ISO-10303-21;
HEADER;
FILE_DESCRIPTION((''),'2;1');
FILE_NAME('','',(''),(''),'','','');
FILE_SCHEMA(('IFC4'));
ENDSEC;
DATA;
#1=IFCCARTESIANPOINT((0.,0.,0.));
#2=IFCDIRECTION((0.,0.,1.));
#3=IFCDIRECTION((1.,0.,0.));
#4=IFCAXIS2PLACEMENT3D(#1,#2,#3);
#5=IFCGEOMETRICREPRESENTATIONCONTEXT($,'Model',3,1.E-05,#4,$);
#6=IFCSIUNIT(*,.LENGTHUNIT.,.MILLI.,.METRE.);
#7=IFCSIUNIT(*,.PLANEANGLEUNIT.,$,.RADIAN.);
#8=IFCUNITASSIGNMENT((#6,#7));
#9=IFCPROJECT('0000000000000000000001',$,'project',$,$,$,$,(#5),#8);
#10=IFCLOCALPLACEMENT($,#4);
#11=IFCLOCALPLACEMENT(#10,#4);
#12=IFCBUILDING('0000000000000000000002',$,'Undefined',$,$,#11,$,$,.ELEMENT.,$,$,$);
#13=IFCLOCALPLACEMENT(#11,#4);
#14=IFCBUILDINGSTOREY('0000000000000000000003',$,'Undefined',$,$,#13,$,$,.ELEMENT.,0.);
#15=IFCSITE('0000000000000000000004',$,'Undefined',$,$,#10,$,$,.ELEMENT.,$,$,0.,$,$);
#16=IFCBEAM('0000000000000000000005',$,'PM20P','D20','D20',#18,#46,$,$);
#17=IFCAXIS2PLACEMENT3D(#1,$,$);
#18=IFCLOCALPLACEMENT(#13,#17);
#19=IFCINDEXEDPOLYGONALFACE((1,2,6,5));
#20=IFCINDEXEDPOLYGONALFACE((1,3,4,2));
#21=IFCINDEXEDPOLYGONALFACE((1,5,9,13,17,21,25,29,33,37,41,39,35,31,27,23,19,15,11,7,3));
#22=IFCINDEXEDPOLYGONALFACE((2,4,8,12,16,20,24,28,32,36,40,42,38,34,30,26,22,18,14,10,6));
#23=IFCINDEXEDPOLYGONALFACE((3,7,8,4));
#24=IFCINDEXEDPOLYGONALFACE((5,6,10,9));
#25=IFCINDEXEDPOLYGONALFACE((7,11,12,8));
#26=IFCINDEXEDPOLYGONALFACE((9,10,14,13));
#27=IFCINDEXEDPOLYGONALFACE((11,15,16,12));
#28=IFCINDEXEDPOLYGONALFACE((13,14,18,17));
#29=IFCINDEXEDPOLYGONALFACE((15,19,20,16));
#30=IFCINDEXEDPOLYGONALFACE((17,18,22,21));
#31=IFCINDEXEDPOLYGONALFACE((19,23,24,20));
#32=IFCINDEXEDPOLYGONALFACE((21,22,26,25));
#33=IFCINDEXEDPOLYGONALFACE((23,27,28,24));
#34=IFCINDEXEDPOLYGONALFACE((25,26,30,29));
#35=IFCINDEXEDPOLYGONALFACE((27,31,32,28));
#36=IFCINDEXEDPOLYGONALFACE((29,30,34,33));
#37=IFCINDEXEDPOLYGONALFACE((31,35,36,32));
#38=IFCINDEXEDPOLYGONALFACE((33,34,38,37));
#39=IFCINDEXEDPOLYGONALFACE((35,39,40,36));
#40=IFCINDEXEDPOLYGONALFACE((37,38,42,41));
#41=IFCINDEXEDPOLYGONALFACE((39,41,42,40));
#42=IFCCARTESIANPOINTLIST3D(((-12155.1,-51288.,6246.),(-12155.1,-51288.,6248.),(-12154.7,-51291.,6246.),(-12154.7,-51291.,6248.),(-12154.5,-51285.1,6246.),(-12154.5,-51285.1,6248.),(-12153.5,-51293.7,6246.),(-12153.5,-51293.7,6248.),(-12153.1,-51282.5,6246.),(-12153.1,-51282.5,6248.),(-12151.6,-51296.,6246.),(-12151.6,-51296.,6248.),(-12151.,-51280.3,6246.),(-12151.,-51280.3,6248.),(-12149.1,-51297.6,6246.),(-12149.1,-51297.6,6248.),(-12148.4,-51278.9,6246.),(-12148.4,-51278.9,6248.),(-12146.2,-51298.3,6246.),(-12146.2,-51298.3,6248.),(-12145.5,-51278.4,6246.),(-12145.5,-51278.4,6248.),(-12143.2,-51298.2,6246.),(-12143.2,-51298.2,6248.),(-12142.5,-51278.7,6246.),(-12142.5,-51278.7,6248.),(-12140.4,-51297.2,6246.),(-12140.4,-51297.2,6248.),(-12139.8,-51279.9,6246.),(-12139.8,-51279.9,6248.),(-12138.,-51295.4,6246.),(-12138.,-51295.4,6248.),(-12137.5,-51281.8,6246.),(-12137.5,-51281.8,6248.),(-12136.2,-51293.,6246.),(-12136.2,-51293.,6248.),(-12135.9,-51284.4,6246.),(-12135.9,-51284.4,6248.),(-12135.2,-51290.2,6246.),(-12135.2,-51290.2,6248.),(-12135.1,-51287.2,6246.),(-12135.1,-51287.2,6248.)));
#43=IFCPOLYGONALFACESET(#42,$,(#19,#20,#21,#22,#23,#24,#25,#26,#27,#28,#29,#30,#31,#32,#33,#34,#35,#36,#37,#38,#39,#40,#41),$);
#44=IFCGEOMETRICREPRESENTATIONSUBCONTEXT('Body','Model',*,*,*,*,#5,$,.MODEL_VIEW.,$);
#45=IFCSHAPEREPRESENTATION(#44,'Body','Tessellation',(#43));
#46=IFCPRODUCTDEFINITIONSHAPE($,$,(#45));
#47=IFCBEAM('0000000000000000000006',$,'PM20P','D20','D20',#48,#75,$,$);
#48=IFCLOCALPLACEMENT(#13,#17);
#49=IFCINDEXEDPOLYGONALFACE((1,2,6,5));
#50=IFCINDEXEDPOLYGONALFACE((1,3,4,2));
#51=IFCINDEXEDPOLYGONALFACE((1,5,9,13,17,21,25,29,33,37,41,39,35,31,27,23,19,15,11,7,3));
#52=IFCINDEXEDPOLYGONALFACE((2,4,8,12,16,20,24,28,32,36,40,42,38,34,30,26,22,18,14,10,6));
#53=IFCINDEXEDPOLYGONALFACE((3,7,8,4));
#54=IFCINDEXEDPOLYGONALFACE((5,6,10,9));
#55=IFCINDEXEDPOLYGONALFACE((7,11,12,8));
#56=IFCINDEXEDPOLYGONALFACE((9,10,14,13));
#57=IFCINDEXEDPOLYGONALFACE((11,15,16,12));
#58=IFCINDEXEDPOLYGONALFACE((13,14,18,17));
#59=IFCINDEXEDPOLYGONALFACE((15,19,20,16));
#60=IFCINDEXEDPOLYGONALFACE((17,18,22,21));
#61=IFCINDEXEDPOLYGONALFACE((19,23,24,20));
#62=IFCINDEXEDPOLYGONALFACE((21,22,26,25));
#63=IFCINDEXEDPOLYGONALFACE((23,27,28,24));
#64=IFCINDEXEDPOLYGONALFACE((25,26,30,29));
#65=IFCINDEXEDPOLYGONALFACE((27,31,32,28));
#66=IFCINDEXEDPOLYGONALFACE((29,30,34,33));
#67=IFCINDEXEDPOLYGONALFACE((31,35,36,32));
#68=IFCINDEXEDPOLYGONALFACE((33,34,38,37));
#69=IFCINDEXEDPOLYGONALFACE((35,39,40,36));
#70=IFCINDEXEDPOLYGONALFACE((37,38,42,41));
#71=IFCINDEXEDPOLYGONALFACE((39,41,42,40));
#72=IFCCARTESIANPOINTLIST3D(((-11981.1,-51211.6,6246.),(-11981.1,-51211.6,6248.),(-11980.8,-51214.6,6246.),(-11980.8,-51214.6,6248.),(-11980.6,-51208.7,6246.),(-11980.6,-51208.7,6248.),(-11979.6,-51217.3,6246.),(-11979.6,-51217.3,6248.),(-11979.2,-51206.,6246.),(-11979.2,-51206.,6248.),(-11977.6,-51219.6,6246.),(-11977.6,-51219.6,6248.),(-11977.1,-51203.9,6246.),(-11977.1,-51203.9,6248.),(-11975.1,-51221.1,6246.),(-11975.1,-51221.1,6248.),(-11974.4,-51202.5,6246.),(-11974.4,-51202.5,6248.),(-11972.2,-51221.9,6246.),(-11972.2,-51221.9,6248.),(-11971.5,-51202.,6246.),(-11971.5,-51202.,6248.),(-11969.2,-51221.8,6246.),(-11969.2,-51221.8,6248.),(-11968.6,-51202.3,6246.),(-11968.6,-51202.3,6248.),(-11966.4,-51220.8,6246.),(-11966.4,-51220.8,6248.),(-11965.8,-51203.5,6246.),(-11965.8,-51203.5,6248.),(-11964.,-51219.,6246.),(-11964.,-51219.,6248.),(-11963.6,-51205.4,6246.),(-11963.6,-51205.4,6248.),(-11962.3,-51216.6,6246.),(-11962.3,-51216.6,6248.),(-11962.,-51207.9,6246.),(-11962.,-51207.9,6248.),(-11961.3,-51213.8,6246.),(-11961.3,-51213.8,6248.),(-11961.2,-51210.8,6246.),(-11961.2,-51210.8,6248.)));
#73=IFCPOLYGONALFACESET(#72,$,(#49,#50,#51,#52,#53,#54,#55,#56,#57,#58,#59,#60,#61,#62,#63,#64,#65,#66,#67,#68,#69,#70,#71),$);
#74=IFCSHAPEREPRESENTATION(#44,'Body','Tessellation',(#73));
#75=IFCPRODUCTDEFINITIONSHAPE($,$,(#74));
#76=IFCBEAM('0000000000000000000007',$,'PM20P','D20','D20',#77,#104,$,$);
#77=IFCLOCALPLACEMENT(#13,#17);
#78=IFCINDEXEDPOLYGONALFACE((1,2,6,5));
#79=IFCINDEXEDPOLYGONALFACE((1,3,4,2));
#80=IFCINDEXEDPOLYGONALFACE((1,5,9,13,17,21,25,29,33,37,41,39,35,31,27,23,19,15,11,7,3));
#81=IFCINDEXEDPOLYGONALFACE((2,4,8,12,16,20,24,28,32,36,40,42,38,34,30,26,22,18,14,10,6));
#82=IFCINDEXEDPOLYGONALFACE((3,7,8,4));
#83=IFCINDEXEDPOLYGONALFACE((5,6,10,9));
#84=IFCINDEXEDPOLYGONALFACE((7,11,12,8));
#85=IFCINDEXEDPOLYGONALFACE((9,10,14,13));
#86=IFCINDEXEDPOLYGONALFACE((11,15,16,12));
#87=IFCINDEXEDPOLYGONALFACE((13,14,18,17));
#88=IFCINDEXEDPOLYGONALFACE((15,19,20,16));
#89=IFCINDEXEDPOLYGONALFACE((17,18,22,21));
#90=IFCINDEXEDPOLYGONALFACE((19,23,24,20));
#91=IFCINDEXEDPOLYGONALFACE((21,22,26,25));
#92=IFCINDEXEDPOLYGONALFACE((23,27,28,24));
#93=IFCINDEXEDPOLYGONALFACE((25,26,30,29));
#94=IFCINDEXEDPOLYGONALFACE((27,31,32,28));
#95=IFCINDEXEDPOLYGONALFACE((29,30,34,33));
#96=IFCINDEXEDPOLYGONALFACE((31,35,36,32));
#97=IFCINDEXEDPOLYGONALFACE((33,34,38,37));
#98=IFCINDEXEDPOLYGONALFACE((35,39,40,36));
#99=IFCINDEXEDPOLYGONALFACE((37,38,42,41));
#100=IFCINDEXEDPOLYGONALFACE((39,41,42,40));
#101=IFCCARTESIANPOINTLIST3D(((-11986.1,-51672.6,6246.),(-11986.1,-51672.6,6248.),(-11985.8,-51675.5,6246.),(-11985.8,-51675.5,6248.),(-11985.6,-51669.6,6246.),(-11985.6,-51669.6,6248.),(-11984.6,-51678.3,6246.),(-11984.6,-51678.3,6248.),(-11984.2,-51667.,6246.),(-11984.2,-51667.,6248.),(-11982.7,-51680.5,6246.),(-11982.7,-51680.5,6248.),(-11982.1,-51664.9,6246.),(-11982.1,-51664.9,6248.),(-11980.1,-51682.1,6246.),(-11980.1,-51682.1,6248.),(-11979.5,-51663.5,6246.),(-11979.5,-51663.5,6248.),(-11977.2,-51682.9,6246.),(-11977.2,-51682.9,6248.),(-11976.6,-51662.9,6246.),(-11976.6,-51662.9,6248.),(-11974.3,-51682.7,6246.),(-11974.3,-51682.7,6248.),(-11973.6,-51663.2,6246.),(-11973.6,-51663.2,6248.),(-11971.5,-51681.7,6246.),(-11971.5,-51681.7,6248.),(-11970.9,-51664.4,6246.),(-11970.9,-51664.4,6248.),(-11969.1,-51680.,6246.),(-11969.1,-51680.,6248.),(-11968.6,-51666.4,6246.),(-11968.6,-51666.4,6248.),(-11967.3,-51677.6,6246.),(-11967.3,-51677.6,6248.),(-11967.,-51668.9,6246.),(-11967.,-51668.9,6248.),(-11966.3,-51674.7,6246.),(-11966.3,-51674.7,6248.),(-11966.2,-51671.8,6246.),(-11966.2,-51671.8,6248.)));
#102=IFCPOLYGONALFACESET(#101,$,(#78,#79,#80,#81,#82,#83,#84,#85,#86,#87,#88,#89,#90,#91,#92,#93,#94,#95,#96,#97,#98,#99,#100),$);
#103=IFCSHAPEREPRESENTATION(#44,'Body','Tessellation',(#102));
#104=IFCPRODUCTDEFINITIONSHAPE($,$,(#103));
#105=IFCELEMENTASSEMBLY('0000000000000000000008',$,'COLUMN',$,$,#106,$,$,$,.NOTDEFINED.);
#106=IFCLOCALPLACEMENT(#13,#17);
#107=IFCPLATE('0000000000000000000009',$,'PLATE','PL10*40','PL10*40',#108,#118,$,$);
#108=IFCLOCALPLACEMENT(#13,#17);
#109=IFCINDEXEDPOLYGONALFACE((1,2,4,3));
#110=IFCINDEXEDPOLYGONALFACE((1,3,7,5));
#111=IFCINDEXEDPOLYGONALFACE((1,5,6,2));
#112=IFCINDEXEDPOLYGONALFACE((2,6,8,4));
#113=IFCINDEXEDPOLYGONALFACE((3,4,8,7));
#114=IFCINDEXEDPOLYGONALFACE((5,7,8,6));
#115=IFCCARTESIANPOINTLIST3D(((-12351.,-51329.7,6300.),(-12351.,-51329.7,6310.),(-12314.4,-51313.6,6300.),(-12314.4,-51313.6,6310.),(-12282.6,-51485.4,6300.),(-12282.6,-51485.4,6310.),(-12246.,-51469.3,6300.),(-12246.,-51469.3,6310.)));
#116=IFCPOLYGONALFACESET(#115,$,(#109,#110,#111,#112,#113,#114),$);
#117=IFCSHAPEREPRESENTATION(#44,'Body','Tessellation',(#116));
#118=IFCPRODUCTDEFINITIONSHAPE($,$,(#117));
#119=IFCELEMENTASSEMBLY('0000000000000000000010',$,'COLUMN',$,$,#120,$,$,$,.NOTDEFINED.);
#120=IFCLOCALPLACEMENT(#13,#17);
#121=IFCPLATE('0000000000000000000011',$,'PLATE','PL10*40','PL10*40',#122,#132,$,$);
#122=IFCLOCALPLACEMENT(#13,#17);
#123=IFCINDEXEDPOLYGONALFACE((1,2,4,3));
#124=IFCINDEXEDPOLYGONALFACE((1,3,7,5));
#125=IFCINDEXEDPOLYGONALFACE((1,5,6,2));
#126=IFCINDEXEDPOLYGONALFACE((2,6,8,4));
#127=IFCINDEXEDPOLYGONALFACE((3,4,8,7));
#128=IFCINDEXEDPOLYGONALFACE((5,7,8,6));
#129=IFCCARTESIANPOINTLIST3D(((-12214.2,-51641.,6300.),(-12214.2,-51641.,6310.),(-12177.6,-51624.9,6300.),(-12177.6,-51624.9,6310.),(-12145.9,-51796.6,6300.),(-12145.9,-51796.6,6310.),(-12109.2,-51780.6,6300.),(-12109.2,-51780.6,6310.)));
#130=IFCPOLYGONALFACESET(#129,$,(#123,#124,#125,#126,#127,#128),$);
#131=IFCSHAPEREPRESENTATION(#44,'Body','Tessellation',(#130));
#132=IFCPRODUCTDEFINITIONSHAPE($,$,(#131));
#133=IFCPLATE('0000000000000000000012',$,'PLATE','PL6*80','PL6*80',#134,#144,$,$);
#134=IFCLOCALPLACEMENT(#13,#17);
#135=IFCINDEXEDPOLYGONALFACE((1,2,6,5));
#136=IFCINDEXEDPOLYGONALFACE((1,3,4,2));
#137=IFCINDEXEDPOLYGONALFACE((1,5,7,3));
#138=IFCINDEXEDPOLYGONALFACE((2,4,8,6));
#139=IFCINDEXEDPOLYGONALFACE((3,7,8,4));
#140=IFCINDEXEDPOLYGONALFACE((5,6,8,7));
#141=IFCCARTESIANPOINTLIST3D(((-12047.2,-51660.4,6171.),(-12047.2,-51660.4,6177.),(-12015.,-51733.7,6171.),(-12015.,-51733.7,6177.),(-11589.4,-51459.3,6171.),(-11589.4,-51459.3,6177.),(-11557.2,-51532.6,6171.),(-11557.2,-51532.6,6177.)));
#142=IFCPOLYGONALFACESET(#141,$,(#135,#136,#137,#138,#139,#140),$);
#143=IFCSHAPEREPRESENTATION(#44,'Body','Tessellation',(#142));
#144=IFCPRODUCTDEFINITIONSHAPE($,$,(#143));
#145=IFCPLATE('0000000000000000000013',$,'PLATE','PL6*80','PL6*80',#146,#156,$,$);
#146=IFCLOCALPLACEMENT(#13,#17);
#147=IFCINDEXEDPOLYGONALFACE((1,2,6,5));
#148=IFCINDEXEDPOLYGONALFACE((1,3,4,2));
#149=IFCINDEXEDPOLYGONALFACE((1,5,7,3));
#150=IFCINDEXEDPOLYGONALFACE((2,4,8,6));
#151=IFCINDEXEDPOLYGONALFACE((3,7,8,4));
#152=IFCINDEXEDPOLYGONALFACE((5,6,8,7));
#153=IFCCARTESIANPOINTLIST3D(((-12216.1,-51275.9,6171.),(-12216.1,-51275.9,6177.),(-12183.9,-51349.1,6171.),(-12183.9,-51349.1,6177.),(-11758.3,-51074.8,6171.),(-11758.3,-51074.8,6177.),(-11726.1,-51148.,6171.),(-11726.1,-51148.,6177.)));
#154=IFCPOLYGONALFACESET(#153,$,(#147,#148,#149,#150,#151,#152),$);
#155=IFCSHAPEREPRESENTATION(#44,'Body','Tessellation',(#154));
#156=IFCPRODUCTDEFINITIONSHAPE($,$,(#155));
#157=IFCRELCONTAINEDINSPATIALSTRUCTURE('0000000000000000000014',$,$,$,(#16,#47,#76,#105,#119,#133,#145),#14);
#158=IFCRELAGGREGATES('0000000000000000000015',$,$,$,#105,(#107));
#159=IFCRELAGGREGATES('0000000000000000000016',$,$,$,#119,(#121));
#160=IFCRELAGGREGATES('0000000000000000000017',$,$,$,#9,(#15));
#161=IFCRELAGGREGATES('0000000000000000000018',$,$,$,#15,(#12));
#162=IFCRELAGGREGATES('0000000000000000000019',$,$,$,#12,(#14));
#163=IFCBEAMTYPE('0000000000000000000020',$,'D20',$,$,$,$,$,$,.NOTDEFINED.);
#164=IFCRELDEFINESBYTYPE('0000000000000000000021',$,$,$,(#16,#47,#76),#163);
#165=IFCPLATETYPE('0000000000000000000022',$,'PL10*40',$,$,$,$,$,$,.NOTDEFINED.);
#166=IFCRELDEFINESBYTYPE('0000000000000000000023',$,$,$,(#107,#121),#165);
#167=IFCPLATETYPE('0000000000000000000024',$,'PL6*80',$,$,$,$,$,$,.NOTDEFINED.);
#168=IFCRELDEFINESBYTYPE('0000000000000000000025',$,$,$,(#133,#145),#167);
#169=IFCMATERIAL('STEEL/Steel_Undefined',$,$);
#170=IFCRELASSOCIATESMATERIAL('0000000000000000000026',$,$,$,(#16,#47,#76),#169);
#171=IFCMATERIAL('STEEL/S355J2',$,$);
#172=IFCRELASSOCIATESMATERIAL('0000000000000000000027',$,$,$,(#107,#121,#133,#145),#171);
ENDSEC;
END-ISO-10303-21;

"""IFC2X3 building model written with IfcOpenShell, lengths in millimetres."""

from ifc_helpers import new_model, si_unit, frame, origin_with_axes, origin_2d_with_axis, place, context, subcontext, project, spatial, polyline, circle, outline, extrude, material, type_object, element, aggregate, save


model = new_model("IFC2X3")

# Units and contexts
model_context = context("Model", 3, precision=1e-05, world=origin_with_axes())
body_context = subcontext(model_context, "Body", "Model", "MODEL_VIEW")
ifc_project = project(units=[si_unit("LENGTHUNIT", "METRE", prefix="MILLI"), si_unit("PLANEANGLEUNIT", "RADIAN")], contexts=[model_context])

# Site, building, storey
site_placement = place(None, origin_with_axes())
site = spatial("IfcSite", under=ifc_project, at=site_placement, Name="Undefined", CompositionType="ELEMENT", RefElevation=0.0)
building_placement = place(site_placement, origin_with_axes())
building = spatial("IfcBuilding", under=site, at=building_placement, Name="Undefined", CompositionType="ELEMENT")
storey_placement = place(building_placement, origin_with_axes())
storey = spatial("IfcBuildingStorey", under=building, at=storey_placement, Name="Undefined", CompositionType="ELEMENT", Elevation=0.0)

# Beams
ifc_material_1 = material(Name="STEEL/Steel_Undefined")
beam_type = type_object("IfcBeamType", Name="D20", PredefinedType="NOTDEFINED")
for number, where, z_axis, x_axis, name in (
    (1, (-12145.1, -51288.4, 6248.0), (-0.402199, 0.915552, 0.0), (0.0, 0.0, -1.0), "PM20P"),
    (2, (-11971.1, -51212.0, 6248.0), (-0.402199, 0.915552, 0.0), (0.0, 0.0, -1.0), "PM20P"),
    (3, (-11976.2, -51672.9, 6248.0), (-0.402199, 0.915552, 0.0), (0.0, 0.0, -1.0), "PM20P"),
):
    element("IfcBeam", number, at=place(storey_placement, frame(where, z_axis=z_axis, x_axis=x_axis)), inside=storey, type_object=beam_type, material=ifc_material_1, Name=name, Description="D20", ObjectType="D20", context=body_context, shape_type="SweptSolid", body=[
        extrude(circle(Radius=10.0, at=origin_2d_with_axis()), frame((2.0, 0.0, 0.0), z_axis=(-1.0, 0.0, 0.0), x_axis=(0.0, -1.0, 0.0)), (0.0, 0.0, 1.0), 2.0),
    ])

# Element assemblies, plates
assembly_1_placement = place(storey_placement, frame((-12298.5, -51399.5, 5840.0), z_axis=(-0.736465, 0.676475, 0.0), x_axis=(0.0, 0.0, 1.0)))
assembly_1 = element("IfcElementAssembly", 4, at=assembly_1_placement, inside=storey, Name="COLUMN", PredefinedType="NOTDEFINED")
ifc_material_2 = material(Name="STEEL/S355J2")
plate_type_1 = type_object("IfcPlateType", Name="PL10*40", PredefinedType="NOTDEFINED")
plate_1_placement = place(storey_placement, frame((-12351.0, -51329.7, 6305.0), z_axis=(0.0, 0.0, 1.0), x_axis=(0.402197, -0.915553, 0.0)))
plate_1 = element("IfcPlate", 5, at=plate_1_placement, type_object=plate_type_1, material=ifc_material_2, Name="PLATE", Description="PL10*40", ObjectType="PL10*40", context=body_context, shape_type="SweptSolid", body=[
    extrude(outline(polyline([(0.0, 0.0), (170.0, 0.0), (170.0, 40.0), (0.0, 40.0), (0.0, 0.0)])), frame((0.0, 0.0, -5.0), z_axis=(0.0, 0.0, 1.0), x_axis=(1.0, 0.0, 0.0)), (0.0, 0.0, 1.0), 10.0),
])
aggregate(assembly_1, [plate_1])
assembly_2_placement = place(storey_placement, frame((-12161.8, -51710.8, 5840.0), z_axis=(-0.736465, 0.676475, 0.0), x_axis=(0.0, 0.0, 1.0)))
assembly_2 = element("IfcElementAssembly", 6, at=assembly_2_placement, inside=storey, Name="COLUMN", PredefinedType="NOTDEFINED")
plate_2_placement = place(storey_placement, frame((-12214.2, -51641.0, 6305.0), z_axis=(0.0, 0.0, 1.0), x_axis=(0.402197, -0.915553, 0.0)))
plate_2 = element("IfcPlate", 7, at=plate_2_placement, type_object=plate_type_1, material=ifc_material_2, Name="PLATE", Description="PL10*40", ObjectType="PL10*40", context=body_context, shape_type="SweptSolid", body=[
    extrude(outline(polyline([(0.0, 0.0), (170.0, 0.0), (170.0, 40.0), (0.0, 40.0), (0.0, 0.0)])), frame((0.0, 0.0, -5.0), z_axis=(0.0, 0.0, 1.0), x_axis=(1.0, 0.0, 0.0)), (0.0, 0.0, 1.0), 10.0),
])
aggregate(assembly_2, [plate_2])

# Plates
plate_type_2 = type_object("IfcPlateType", Name="PL6*80", PredefinedType="NOTDEFINED")
for number, where, z_axis, x_axis, name in (
    (8, (-12047.2, -51660.4, 6174.0), (0.0, 0.0, 1.0), (0.402199, -0.915552, 0.0), "PLATE"),
    (9, (-12216.1, -51275.9, 6174.0), (0.0, 0.0, 1.0), (0.402199, -0.915552, 0.0), "PLATE"),
):
    element("IfcPlate", number, at=place(storey_placement, frame(where, z_axis=z_axis, x_axis=x_axis)), inside=storey, type_object=plate_type_2, material=ifc_material_2, Name=name, Description="PL6*80", ObjectType="PL6*80", context=body_context, shape_type="SweptSolid", body=[
        extrude(outline(polyline([(0.0, 0.0), (80.0, 0.0), (80.0, 500.0), (0.0, 500.0), (0.0, 0.0)])), frame((0.0, 0.0, -3.0), z_axis=(0.0, 0.0, 1.0), x_axis=(1.0, 0.0, 0.0)), (0.0, 0.0, 1.0), 6.0),
    ])

save(model, "model.ifc")
